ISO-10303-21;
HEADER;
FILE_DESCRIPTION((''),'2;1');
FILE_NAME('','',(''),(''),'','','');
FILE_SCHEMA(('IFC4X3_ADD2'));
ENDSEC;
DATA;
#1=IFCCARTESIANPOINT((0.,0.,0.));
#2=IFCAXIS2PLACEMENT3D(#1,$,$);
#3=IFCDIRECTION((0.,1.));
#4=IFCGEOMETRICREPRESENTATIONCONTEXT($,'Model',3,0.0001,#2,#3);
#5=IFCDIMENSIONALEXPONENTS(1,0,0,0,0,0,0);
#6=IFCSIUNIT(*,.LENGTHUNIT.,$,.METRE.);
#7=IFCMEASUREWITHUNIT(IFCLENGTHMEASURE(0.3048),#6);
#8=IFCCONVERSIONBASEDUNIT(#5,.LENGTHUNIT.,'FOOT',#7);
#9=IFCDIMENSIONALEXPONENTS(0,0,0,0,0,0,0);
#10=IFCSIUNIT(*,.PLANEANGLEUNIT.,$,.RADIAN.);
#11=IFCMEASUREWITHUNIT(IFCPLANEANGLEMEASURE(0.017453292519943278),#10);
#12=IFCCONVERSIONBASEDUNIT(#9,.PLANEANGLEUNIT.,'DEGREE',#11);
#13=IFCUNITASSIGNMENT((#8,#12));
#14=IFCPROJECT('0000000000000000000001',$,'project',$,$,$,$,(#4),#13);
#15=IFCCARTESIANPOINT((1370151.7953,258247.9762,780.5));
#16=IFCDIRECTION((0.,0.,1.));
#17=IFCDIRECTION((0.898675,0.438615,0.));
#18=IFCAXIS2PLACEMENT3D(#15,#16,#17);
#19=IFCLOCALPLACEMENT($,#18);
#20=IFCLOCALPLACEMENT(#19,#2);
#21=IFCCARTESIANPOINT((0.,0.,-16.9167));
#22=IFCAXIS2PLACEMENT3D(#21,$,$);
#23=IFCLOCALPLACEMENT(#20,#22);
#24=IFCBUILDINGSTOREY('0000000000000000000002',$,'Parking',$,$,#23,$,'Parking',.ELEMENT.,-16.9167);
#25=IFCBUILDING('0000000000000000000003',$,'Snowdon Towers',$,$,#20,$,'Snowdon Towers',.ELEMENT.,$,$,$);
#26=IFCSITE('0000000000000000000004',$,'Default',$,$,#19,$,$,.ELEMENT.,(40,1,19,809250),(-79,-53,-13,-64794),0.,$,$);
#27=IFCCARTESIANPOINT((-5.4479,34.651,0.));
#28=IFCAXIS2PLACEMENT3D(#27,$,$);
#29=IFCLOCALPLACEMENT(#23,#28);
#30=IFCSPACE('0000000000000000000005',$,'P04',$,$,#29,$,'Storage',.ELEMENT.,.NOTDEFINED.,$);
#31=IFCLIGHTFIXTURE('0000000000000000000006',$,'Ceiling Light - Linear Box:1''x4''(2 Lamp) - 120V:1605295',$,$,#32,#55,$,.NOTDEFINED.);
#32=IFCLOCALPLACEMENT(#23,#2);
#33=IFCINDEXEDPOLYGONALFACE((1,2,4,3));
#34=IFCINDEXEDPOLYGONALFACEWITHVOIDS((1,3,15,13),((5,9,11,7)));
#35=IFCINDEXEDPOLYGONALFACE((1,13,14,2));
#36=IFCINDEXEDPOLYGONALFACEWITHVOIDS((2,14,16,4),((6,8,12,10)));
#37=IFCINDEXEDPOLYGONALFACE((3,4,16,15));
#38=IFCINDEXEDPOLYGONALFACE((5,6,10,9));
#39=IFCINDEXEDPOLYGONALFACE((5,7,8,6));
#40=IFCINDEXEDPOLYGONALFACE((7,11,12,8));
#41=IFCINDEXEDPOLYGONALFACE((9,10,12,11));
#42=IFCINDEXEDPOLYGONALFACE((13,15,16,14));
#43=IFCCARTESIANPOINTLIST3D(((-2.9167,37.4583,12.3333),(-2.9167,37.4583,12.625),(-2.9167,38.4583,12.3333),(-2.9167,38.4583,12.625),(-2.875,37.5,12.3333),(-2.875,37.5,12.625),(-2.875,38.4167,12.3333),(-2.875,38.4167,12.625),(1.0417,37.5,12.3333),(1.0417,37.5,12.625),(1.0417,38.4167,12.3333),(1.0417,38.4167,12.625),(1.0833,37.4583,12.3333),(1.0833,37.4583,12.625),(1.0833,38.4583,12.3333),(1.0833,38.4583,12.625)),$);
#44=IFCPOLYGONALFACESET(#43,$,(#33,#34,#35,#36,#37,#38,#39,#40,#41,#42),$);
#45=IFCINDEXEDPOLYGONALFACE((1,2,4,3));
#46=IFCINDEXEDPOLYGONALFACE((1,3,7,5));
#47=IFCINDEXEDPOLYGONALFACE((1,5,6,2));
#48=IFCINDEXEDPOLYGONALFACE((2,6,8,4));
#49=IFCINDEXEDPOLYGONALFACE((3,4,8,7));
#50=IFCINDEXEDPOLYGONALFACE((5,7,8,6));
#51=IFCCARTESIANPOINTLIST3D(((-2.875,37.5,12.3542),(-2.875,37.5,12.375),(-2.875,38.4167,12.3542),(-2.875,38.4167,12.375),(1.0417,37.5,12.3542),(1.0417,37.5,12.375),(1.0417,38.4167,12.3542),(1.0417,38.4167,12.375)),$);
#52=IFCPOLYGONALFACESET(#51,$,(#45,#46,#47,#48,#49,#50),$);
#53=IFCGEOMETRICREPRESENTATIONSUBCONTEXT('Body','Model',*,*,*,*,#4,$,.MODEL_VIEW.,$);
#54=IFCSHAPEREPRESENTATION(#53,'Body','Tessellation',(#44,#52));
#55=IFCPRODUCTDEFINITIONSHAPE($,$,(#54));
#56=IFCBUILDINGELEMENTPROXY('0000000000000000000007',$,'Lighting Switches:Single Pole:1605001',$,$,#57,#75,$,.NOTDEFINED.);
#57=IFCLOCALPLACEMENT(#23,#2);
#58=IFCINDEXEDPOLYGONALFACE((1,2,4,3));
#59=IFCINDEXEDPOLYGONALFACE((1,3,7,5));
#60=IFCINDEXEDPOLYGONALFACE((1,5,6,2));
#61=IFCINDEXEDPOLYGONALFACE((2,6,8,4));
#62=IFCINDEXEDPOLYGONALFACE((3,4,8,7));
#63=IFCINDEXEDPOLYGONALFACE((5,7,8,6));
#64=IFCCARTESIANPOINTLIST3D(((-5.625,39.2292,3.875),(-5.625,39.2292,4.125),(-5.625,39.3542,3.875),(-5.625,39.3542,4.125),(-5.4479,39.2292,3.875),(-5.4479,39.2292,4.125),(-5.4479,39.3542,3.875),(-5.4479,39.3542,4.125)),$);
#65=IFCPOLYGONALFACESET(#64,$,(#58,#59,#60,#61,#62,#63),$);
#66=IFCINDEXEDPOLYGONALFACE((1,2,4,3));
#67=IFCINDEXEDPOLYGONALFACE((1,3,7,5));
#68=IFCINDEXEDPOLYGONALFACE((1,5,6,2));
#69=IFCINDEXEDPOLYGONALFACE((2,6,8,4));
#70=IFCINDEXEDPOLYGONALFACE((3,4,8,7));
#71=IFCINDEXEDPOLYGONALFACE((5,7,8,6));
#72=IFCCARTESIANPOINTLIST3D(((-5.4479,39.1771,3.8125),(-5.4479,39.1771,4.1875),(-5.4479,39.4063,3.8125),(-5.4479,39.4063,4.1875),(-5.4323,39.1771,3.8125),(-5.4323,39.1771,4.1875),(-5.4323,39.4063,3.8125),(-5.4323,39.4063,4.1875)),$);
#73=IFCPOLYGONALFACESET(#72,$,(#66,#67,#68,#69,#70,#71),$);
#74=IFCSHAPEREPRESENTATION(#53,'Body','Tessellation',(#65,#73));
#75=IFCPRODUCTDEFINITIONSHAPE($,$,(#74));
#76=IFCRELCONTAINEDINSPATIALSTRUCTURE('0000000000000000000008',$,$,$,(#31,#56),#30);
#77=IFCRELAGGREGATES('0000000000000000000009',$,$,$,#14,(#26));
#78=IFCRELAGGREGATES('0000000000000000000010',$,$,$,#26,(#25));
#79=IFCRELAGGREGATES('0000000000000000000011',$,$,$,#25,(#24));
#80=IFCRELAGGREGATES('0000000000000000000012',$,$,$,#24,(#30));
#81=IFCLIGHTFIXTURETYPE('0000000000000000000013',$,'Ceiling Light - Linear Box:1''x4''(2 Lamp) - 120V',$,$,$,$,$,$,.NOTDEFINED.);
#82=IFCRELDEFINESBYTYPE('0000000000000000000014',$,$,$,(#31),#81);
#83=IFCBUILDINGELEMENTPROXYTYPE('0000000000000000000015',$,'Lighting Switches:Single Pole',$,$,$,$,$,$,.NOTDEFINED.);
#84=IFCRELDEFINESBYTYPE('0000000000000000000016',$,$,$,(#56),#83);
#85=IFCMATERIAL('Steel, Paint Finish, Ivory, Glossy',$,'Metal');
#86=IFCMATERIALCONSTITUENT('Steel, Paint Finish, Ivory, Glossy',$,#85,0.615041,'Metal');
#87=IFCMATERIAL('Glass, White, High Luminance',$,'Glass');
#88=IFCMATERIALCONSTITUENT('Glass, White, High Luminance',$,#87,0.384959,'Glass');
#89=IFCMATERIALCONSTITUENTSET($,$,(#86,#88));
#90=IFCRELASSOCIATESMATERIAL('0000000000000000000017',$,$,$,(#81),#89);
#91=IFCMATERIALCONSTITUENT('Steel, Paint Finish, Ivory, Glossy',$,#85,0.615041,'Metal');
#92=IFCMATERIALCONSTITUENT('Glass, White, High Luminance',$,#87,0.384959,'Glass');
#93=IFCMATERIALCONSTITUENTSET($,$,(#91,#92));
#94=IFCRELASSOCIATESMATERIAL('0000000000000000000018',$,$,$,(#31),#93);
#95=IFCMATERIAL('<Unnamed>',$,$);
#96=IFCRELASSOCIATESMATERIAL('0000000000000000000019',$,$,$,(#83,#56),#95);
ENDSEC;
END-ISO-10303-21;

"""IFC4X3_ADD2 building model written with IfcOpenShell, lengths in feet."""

from ifc_helpers import new_model, entity, si_unit, converted_unit, direction, frame, frame_2d, origin, origin_2d_with_axis, place, context, subcontext, project, spatial, polyline, rectangle, outline, extrude, source, transform, mapped, material, constituent, constituent_set, type_object, type_shapes, element, save


model = new_model("IFC4X3_ADD2")

# Units and contexts
model_context = context("Model", 3, precision=0.0001, world=origin(), true_north=direction((0.0, 1.0)))
body_context = subcontext(model_context, "Body", "Model", "MODEL_VIEW")
ifc_project = project(units=[converted_unit("LENGTHUNIT", "FOOT", entity("IfcLengthMeasure", 0.3048), si_unit("LENGTHUNIT", "METRE"), dimensions=[1, 0, 0, 0, 0, 0, 0]), converted_unit("PLANEANGLEUNIT", "DEGREE", entity("IfcPlaneAngleMeasure", 0.017453292519943278), si_unit("PLANEANGLEUNIT", "RADIAN"), dimensions=[0, 0, 0, 0, 0, 0, 0])], contexts=[model_context])

# Site, building, storey
site_placement = place(None, frame((1370151.7953, 258247.9762, 780.5), z_axis=(0.0, 0.0, 1.0), x_axis=(0.898675, 0.438615, 0.0)))
site = spatial("IfcSite", under=ifc_project, at=site_placement, Name="Default", CompositionType="ELEMENT", RefLatitude=(40, 1, 19, 809250), RefLongitude=(-79, -53, -13, -64794), RefElevation=0.0)
building_placement = place(site_placement, origin())
building = spatial("IfcBuilding", under=site, at=building_placement, Name="Snowdon Towers", LongName="Snowdon Towers", CompositionType="ELEMENT")
storey_placement = place(building_placement, frame((0.0, 0.0, -16.9167)))
storey = spatial("IfcBuildingStorey", under=building, at=storey_placement, Name="Parking", LongName="Parking", CompositionType="ELEMENT", Elevation=-16.9167)

# Shared definitions
ifc_material_1 = material(Name="Steel, Paint Finish, Ivory, Glossy", Category="Metal")
ifc_material_2 = material(Name="Glass, White, High Luminance", Category="Glass")
ifc_constituent_1 = constituent(ifc_material_1, Name="Steel, Paint Finish, Ivory, Glossy", Category="Metal", fraction=0.615041)
ifc_constituent_2 = constituent(ifc_material_2, Name="Glass, White, High Luminance", Category="Glass", fraction=0.384959)
ifc_constituent_set_1 = constituent_set(constituents=[ifc_constituent_1, ifc_constituent_2])
light_fixture_type = type_object("IfcLightFixtureType", Name="Ceiling Light - Linear Box:1'x4'(2 Lamp) - 120V", PredefinedType="NOTDEFINED", material=ifc_constituent_set_1)
shared_shape_1 = source(origin(), body_context, "Body", "SweptSolid", [
    extrude(outline(polyline([(-2.0, -0.5), (2.0, -0.5), (2.0, 0.5), (-2.0, 0.5), (-2.0, -0.5)]), holes=[polyline([(-1.9583, -0.4583), (-1.9583, 0.4583), (1.9583, 0.4583), (1.9583, -0.4583), (-1.9583, -0.4583)])]), frame((0.0, -0.5, 0.0), z_axis=(0.0, 0.0, 1.0), x_axis=(-1.0, 0.0, 0.0)), (0.0, 0.0, 1.0), 0.2917),
    extrude(rectangle(XDim=3.9167, YDim=0.9167, at=origin_2d_with_axis()), frame((0.0, -0.5, 0.25), z_axis=(0.0, 0.0, 1.0), x_axis=(-1.0, 0.0, 0.0)), (0.0, 0.0, 1.0), 0.0208),
])
type_shapes(light_fixture_type, [shared_shape_1])

# Shared definitions
space_1_placement = place(storey_placement, frame((-5.4479, 34.651, 0.0)))
space_1 = spatial("IfcSpace", under=storey, at=space_1_placement, Name="P04", LongName="Storage", CompositionType="ELEMENT", PredefinedType="NOTDEFINED")

# Light fixture
ifc_constituent_3 = constituent(ifc_material_1, Name="Steel, Paint Finish, Ivory, Glossy", Category="Metal", fraction=0.615041)
ifc_constituent_4 = constituent(ifc_material_2, Name="Glass, White, High Luminance", Category="Glass", fraction=0.384959)
ifc_constituent_set_2 = constituent_set(constituents=[ifc_constituent_3, ifc_constituent_4])
light_fixture_1_placement = place(space_1_placement, frame((4.5312, 2.8073, 12.625), z_axis=(0.0, 0.0, -1.0), x_axis=(1.0, 0.0, 0.0)))
element("IfcLightFixture", 1, at=light_fixture_1_placement, inside=space_1, type_object=light_fixture_type, material=ifc_constituent_set_2, Name="Ceiling Light - Linear Box:1'x4'(2 Lamp) - 120V:1605295", PredefinedType="NOTDEFINED", context=body_context, shape_type="MappedRepresentation", body=[
    mapped(shared_shape_1, transform((0.0, 0.0, 0.0), scale=1.0)),
])

# Building element proxy
ifc_material_3 = material(Name="<Unnamed>")
building_element_proxy_type = type_object("IfcBuildingElementProxyType", Name="Lighting Switches:Single Pole", PredefinedType="NOTDEFINED", material=ifc_material_3)
shared_shape_2 = source(origin(), body_context, "Body", "SweptSolid", [
    extrude(rectangle(XDim=0.125, YDim=0.25, at=origin_2d_with_axis()), frame((0.0, 0.0, -0.1771), z_axis=(0.0, 0.0, 1.0), x_axis=(-1.0, 0.0, 0.0)), (0.0, 0.0, 1.0), 0.1771),
    extrude(rectangle(XDim=0.2292, YDim=0.375, at=frame_2d((0.0, 0.0), x_axis=(1.0, 0.0))), frame((0.0, 0.0, 0.0), z_axis=(0.0, 0.0, 1.0), x_axis=(-1.0, 0.0, 0.0)), (0.0, 0.0, 1.0), 0.0156),
])
type_shapes(building_element_proxy_type, [shared_shape_2])
proxy_placement = place(space_1_placement, frame((0.0, 4.6406, 4.0), z_axis=(1.0, 0.0, 0.0), x_axis=(0.0, 1.0, 0.0)))
element("IfcBuildingElementProxy", 2, at=proxy_placement, inside=space_1, type_object=building_element_proxy_type, material=ifc_material_3, Name="Lighting Switches:Single Pole:1605001", PredefinedType="NOTDEFINED", context=body_context, shape_type="MappedRepresentation", body=[
    mapped(shared_shape_2, transform((0.0, 0.0, 0.0), scale=1.0)),
])

save(model, "model.ifc")
